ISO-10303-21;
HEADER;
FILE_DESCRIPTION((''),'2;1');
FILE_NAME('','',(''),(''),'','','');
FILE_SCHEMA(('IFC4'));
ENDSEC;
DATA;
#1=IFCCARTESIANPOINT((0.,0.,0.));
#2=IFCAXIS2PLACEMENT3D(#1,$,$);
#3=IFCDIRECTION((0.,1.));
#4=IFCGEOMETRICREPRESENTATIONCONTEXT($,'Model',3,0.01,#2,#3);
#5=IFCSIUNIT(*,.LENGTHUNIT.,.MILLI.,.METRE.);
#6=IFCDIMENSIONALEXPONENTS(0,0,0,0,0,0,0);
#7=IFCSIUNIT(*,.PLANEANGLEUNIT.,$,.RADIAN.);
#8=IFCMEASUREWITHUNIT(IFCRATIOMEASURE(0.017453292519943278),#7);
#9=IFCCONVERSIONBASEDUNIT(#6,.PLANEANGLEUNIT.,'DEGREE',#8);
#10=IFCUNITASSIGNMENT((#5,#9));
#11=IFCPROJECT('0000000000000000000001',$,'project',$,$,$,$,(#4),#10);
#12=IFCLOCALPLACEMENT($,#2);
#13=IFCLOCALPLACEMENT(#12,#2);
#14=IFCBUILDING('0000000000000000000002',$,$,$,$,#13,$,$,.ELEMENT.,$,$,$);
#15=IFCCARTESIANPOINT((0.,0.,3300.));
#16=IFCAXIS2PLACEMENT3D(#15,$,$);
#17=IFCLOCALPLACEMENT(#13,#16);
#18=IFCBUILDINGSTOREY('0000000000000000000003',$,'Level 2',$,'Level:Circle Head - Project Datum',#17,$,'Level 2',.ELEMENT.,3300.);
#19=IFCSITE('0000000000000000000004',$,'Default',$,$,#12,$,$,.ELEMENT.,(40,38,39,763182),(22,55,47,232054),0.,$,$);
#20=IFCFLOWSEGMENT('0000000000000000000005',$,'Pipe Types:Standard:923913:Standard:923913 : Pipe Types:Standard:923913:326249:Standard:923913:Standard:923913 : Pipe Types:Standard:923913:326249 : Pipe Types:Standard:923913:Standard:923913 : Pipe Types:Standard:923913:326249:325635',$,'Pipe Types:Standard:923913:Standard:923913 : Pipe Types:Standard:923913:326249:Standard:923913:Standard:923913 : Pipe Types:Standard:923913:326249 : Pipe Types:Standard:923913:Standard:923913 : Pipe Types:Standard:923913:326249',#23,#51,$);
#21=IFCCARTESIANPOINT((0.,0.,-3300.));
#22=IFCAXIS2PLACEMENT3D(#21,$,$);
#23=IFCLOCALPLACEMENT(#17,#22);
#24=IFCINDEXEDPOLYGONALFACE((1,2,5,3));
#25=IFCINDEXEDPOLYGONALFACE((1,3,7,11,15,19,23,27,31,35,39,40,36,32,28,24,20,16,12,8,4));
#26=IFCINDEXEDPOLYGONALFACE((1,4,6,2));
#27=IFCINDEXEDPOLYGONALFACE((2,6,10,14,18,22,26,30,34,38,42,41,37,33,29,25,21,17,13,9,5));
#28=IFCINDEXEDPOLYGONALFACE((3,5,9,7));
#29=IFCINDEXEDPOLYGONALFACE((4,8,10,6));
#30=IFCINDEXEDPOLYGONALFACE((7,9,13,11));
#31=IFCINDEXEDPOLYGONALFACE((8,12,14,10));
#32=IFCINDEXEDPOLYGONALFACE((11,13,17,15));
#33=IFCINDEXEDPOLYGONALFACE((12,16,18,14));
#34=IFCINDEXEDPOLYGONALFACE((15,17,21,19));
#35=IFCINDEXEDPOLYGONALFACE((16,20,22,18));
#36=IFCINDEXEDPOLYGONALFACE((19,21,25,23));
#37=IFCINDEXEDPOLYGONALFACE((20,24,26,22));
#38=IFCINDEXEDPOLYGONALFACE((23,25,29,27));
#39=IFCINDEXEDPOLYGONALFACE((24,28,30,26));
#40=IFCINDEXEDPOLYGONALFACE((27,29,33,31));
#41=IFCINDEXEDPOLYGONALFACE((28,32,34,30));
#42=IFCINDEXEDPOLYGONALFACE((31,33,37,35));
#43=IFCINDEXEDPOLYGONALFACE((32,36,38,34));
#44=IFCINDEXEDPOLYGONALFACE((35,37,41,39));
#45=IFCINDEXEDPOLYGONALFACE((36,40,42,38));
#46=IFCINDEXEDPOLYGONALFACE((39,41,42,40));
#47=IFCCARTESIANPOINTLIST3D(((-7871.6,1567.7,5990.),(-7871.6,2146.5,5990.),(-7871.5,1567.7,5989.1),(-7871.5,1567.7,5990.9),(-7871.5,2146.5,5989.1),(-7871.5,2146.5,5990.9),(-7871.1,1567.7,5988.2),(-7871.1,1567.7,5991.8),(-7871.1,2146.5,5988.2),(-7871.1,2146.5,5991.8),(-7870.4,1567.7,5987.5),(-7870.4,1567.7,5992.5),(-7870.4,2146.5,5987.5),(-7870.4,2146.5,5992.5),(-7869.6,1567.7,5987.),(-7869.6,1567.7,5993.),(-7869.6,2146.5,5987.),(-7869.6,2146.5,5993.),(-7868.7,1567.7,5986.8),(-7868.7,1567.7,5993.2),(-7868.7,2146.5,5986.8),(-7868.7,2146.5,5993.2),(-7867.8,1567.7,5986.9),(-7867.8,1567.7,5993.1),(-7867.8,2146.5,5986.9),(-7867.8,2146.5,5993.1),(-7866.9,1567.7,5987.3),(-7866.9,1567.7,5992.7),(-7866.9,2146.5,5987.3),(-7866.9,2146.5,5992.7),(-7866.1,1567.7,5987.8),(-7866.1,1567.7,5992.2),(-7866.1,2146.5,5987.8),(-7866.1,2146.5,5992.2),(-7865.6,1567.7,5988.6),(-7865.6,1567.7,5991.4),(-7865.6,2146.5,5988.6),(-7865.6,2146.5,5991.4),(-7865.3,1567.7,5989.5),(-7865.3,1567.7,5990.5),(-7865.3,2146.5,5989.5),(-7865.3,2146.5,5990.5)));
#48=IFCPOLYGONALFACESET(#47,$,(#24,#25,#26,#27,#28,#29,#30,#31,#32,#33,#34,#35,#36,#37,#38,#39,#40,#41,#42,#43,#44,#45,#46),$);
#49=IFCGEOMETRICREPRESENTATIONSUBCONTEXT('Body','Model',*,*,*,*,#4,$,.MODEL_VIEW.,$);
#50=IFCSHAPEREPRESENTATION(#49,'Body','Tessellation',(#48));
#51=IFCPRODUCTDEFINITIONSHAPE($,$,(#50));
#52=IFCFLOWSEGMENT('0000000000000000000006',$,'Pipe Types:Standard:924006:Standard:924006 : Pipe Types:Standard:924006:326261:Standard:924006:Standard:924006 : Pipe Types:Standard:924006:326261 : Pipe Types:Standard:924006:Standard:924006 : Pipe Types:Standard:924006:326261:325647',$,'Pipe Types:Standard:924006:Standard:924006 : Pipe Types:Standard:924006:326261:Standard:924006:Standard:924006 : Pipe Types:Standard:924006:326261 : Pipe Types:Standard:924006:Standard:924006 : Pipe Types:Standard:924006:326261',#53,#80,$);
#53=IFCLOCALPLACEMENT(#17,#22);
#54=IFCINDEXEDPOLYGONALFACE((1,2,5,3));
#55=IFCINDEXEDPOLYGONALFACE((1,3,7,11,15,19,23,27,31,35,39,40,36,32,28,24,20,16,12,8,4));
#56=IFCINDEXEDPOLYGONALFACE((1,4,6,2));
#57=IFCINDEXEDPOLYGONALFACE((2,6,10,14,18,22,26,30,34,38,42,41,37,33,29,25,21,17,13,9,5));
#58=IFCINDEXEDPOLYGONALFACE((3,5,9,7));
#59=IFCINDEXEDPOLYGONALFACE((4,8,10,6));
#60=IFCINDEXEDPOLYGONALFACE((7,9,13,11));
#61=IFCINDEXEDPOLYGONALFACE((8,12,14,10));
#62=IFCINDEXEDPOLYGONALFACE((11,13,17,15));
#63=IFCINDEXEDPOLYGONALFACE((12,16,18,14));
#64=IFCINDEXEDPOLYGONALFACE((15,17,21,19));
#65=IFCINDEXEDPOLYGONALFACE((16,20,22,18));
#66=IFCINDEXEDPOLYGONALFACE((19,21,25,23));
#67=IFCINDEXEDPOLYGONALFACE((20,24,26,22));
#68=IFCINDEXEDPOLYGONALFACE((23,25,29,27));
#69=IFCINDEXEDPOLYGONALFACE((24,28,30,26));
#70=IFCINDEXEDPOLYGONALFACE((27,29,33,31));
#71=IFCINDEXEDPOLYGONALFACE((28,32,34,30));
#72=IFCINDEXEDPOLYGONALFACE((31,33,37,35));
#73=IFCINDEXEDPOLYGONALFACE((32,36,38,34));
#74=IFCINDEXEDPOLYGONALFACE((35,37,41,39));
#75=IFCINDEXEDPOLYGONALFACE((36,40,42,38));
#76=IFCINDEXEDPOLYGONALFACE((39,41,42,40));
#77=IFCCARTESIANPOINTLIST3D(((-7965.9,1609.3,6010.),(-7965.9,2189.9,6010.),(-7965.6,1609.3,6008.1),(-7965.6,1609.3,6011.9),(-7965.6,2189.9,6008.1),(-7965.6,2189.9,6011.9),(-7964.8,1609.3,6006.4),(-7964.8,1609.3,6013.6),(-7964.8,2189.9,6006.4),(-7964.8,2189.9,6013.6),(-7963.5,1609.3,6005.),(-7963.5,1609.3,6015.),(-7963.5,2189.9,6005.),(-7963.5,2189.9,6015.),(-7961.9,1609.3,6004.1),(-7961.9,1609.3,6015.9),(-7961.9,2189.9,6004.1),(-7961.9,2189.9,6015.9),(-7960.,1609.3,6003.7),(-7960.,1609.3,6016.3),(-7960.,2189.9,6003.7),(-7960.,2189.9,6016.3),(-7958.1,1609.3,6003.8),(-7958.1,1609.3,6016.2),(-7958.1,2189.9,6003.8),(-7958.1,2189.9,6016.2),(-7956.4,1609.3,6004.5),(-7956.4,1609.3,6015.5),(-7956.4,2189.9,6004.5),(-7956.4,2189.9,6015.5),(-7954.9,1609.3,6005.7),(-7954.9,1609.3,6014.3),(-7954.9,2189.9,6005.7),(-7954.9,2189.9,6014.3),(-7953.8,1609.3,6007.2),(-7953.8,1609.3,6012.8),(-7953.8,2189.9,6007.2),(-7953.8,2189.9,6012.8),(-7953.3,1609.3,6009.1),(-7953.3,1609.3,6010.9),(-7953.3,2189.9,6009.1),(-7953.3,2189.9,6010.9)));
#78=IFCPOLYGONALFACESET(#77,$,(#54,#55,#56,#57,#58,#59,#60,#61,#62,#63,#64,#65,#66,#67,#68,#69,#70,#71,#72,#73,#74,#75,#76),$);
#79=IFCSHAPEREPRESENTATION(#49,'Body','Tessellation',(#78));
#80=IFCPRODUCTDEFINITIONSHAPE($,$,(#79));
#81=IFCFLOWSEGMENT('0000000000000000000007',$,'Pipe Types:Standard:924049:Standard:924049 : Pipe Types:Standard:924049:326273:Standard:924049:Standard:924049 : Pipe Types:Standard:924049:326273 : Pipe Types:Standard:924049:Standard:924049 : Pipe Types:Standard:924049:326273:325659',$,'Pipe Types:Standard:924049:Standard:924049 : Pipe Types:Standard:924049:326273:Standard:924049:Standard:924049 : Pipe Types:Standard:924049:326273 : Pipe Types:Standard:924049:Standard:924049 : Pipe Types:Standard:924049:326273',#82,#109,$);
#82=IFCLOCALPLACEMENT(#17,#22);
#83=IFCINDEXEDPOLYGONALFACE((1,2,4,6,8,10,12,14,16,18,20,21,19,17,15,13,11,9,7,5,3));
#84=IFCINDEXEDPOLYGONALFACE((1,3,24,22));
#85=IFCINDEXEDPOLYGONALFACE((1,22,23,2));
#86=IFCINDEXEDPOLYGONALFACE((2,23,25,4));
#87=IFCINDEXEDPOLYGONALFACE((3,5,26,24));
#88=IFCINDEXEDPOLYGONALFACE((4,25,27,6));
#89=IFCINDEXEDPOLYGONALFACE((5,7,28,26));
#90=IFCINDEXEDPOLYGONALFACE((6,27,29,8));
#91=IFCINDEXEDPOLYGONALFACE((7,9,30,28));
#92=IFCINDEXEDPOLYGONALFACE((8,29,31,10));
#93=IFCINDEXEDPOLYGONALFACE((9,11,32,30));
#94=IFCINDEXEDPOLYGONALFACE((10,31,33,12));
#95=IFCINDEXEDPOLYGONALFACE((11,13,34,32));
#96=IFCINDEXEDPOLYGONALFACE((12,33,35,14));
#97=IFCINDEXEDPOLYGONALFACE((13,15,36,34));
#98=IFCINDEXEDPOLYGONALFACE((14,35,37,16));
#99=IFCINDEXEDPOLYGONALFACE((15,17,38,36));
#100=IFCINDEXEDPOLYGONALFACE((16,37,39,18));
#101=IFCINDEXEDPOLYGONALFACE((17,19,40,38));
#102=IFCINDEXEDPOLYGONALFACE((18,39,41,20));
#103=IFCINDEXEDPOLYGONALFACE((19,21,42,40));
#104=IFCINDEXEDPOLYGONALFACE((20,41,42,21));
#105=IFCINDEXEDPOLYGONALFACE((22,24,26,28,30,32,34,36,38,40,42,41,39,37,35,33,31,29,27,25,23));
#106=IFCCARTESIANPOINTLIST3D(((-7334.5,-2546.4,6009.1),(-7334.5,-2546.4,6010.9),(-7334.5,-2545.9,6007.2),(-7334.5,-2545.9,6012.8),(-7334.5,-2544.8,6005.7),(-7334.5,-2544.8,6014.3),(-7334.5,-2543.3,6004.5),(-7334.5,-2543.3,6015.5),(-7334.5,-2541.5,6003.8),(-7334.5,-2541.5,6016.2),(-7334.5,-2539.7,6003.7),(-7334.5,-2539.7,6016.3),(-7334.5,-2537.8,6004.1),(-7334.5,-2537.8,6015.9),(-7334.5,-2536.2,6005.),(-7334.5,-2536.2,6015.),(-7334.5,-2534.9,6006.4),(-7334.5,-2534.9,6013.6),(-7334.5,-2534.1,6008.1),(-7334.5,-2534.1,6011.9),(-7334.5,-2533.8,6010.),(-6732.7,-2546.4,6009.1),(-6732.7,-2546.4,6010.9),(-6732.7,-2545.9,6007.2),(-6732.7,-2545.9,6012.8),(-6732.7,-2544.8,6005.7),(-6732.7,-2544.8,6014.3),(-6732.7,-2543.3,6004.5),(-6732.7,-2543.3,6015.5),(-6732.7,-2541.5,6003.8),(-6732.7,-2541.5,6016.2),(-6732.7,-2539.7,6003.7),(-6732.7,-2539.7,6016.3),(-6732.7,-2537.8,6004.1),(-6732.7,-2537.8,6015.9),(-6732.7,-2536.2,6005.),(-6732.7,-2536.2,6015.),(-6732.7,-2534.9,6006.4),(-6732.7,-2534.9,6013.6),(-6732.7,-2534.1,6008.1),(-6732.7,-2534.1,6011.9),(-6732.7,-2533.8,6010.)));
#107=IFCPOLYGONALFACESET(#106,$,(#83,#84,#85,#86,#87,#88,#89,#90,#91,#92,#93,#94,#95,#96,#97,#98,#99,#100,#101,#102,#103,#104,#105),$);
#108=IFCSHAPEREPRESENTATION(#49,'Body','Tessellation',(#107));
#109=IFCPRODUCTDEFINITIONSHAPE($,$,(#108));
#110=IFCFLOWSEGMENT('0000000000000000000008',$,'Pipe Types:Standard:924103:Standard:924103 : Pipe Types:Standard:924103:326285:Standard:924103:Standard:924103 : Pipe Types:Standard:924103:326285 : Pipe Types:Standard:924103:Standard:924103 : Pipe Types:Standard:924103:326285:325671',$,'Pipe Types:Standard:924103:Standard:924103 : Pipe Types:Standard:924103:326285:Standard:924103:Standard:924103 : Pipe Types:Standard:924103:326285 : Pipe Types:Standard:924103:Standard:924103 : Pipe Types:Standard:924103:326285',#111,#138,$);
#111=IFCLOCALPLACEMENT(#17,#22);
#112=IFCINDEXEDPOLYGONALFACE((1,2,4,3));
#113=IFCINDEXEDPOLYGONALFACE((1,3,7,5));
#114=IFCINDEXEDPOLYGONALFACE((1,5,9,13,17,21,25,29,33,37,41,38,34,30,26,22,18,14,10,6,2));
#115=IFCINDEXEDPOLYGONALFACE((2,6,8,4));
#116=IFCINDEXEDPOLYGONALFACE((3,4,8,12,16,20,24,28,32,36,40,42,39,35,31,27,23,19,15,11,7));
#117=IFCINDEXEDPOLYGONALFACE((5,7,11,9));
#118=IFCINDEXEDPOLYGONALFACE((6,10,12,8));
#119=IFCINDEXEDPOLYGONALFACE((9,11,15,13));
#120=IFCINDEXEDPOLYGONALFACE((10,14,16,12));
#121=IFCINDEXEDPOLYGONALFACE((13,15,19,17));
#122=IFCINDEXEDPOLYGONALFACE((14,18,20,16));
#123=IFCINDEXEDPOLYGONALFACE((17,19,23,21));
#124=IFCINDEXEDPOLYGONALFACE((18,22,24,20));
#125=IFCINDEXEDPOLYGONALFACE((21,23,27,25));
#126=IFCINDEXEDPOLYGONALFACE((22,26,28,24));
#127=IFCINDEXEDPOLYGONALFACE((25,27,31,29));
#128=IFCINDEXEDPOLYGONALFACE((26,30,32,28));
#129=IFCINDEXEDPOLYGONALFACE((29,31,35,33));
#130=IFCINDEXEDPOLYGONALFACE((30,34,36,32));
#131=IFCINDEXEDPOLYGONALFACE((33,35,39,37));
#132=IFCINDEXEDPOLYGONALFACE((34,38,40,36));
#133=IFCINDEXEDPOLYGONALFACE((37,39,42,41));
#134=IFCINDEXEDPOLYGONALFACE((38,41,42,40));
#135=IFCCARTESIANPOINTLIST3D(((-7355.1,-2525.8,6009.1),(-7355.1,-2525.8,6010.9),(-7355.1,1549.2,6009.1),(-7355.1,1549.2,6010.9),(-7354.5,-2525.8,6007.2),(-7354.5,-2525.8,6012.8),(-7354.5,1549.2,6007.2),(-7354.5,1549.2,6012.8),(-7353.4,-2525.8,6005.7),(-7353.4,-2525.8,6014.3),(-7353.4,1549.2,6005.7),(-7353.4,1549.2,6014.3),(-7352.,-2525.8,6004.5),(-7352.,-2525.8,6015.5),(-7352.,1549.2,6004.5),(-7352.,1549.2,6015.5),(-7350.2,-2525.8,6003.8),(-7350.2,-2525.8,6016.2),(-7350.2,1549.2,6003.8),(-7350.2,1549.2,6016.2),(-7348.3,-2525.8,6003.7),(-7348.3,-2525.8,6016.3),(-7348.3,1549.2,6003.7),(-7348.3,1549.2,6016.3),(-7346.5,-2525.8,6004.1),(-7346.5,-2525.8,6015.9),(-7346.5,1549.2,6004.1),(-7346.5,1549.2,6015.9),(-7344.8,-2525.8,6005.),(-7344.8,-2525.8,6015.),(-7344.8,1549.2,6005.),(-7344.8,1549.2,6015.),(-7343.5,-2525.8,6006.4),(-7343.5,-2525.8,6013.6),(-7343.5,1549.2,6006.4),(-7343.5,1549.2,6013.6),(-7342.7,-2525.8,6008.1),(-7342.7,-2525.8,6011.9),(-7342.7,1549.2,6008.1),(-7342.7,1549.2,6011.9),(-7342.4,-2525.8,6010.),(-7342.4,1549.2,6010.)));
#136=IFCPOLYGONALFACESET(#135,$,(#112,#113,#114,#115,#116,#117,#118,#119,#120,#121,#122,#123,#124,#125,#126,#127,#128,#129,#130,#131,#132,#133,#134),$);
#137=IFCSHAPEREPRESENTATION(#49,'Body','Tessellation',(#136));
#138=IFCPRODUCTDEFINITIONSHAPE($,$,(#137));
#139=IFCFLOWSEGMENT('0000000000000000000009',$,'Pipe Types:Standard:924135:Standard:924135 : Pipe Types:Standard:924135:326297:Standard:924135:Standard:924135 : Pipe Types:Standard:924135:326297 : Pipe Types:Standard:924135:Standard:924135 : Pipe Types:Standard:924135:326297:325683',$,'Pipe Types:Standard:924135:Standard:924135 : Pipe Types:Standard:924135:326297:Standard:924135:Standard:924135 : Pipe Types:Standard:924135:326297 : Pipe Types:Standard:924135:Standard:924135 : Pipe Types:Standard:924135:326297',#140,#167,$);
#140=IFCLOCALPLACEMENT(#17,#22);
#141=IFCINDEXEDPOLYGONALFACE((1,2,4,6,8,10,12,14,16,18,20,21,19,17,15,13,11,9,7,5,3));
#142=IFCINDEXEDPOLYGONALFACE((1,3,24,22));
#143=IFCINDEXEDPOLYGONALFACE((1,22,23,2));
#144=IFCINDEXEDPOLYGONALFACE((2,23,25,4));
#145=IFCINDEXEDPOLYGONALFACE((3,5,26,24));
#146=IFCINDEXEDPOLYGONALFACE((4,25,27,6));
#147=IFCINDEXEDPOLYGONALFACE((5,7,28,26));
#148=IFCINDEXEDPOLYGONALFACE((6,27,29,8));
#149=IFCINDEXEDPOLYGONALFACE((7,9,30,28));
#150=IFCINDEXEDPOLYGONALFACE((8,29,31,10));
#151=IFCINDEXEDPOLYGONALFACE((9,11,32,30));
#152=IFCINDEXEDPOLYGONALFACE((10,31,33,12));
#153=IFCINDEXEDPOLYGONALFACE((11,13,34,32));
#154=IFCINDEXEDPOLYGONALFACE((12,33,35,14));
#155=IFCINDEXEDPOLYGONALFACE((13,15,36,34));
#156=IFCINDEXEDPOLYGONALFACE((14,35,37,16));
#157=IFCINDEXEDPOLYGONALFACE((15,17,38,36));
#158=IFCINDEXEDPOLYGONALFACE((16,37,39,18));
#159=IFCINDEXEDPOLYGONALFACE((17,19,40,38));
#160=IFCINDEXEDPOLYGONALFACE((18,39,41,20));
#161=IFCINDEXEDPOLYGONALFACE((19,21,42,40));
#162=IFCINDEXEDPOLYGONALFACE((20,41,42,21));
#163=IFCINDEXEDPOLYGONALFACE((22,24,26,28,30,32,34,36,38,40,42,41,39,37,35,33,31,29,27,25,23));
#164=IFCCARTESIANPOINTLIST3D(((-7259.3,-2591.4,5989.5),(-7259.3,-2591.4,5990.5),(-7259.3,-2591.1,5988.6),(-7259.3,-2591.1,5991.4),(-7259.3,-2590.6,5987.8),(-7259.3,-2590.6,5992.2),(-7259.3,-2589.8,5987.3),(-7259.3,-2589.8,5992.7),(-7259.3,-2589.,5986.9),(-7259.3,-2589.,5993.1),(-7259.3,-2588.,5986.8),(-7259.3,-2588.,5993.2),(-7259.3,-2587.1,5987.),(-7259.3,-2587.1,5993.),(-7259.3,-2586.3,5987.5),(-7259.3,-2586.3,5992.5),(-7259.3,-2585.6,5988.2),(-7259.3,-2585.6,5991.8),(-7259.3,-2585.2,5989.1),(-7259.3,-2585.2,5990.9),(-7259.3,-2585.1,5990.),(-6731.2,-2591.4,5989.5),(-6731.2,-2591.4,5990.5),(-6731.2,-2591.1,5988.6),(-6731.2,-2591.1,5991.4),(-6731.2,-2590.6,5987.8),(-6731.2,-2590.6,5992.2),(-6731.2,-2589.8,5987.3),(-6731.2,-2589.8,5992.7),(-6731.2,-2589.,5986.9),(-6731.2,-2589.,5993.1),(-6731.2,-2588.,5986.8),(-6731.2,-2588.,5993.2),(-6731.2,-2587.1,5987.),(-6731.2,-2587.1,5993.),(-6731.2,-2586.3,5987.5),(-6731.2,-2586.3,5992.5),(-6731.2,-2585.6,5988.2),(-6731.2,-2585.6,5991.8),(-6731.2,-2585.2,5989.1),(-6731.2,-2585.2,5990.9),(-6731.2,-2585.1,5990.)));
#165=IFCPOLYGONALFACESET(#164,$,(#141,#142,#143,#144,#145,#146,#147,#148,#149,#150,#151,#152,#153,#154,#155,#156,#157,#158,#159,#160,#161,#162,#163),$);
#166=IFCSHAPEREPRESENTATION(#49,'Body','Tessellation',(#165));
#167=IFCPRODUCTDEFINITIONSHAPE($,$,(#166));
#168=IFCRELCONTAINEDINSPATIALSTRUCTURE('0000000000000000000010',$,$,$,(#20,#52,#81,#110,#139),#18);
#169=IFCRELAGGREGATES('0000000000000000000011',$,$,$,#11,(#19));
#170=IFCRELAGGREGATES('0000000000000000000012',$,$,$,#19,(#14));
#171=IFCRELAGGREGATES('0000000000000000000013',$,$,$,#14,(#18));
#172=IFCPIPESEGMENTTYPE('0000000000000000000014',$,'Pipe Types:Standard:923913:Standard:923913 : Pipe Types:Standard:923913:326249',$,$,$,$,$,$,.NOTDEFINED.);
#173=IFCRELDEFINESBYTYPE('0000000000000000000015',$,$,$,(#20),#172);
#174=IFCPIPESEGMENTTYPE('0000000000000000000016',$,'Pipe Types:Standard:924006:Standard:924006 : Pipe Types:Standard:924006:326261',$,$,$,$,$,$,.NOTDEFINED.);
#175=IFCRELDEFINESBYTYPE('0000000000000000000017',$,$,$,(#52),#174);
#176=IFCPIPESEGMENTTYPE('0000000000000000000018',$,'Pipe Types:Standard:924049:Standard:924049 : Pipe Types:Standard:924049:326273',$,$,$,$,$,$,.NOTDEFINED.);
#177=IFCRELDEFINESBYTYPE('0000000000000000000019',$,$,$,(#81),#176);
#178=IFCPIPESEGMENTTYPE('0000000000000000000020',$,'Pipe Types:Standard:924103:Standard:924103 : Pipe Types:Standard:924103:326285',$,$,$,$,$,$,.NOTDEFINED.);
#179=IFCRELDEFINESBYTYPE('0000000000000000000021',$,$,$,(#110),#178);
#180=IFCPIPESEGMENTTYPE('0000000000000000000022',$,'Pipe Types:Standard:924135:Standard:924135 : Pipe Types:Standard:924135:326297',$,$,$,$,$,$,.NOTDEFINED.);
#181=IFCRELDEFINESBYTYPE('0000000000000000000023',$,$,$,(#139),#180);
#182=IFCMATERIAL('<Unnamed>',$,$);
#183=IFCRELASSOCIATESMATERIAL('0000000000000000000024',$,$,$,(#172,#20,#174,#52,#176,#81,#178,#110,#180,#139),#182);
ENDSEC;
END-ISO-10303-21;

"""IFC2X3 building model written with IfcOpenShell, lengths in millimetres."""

from ifc_helpers import new_model, entity, si_unit, converted_unit, direction, frame, origin, origin_2d_with_axis, place, context, subcontext, project, spatial, circle, extrude, source, transform, mapped, material, type_object, type_shapes, element, save


model = new_model("IFC2X3")

# Units and contexts
model_context = context("Model", 3, precision=0.01, world=origin(), true_north=direction((0.0, 1.0)))
body_context = subcontext(model_context, "Body", "Model", "MODEL_VIEW")
ifc_project = project(units=[si_unit("LENGTHUNIT", "METRE", prefix="MILLI"), converted_unit("PLANEANGLEUNIT", "DEGREE", entity("IfcRatioMeasure", 0.017453292519943278), si_unit("PLANEANGLEUNIT", "RADIAN"), dimensions=[0, 0, 0, 0, 0, 0, 0])], contexts=[model_context])

# Site, building, storey
site_placement = place(None, origin())
site = spatial("IfcSite", under=ifc_project, at=site_placement, Name="Default", CompositionType="ELEMENT", RefLatitude=(40, 38, 39, 763182), RefLongitude=(22, 55, 47, 232054), RefElevation=0.0)
building_placement = place(site_placement, origin())
building = spatial("IfcBuilding", under=site, at=building_placement, CompositionType="ELEMENT")
storey_placement = place(building_placement, frame((0.0, 0.0, 3300.0)))
storey = spatial("IfcBuildingStorey", under=building, at=storey_placement, Name="Level 2", ObjectType="Level:Circle Head - Project Datum", LongName="Level 2", CompositionType="ELEMENT", Elevation=3300.0)

# Flow segments
ifc_material_1 = material(Name="<Unnamed>")
pipe_segment_type_1 = type_object("IfcPipeSegmentType", Name="Pipe Types:Standard:923913:Standard:923913 : Pipe Types:Standard:923913:326249", PredefinedType="NOTDEFINED", material=ifc_material_1)
shared_shape_1 = source(origin(), body_context, "Body", "SweptSolid", [
    extrude(circle(Radius=3.2, at=origin_2d_with_axis()), frame((-7868.5, 1567.7, 5990.0), z_axis=(0.0, 1.0, 0.0), x_axis=(-1.0, 0.0, 0.0)), (0.0, 0.0, 1.0), 578.8),
])
type_shapes(pipe_segment_type_1, [shared_shape_1])
flow_segment_1_placement = place(storey_placement, frame((0.0, 0.0, -3300.0)))
element("IfcFlowSegment", 1, at=flow_segment_1_placement, inside=storey, type_object=pipe_segment_type_1, material=ifc_material_1, Name="Pipe Types:Standard:923913:Standard:923913 : Pipe Types:Standard:923913:326249:Standard:923913:Standard:923913 : Pipe Types:Standard:923913:326249 : Pipe Types:Standard:923913:Standard:923913 : Pipe Types:Standard:923913:326249:325635", ObjectType="Pipe Types:Standard:923913:Standard:923913 : Pipe Types:Standard:923913:326249:Standard:923913:Standard:923913 : Pipe Types:Standard:923913:326249 : Pipe Types:Standard:923913:Standard:923913 : Pipe Types:Standard:923913:326249", context=body_context, shape_type="MappedRepresentation", body=[
    mapped(shared_shape_1, transform((0.0, 0.0, 0.0), scale=1.0)),
])
pipe_segment_type_2 = type_object("IfcPipeSegmentType", Name="Pipe Types:Standard:924006:Standard:924006 : Pipe Types:Standard:924006:326261", PredefinedType="NOTDEFINED", material=ifc_material_1)
shared_shape_2 = source(origin(), body_context, "Body", "SweptSolid", [
    extrude(circle(Radius=6.3, at=origin_2d_with_axis()), frame((-7959.6, 1609.3, 6010.0), z_axis=(0.0, 1.0, 0.0), x_axis=(-1.0, 0.0, 0.0)), (0.0, 0.0, 1.0), 580.6),
])
type_shapes(pipe_segment_type_2, [shared_shape_2])
flow_segment_2_placement = place(storey_placement, frame((0.0, 0.0, -3300.0)))
element("IfcFlowSegment", 2, at=flow_segment_2_placement, inside=storey, type_object=pipe_segment_type_2, material=ifc_material_1, Name="Pipe Types:Standard:924006:Standard:924006 : Pipe Types:Standard:924006:326261:Standard:924006:Standard:924006 : Pipe Types:Standard:924006:326261 : Pipe Types:Standard:924006:Standard:924006 : Pipe Types:Standard:924006:326261:325647", ObjectType="Pipe Types:Standard:924006:Standard:924006 : Pipe Types:Standard:924006:326261:Standard:924006:Standard:924006 : Pipe Types:Standard:924006:326261 : Pipe Types:Standard:924006:Standard:924006 : Pipe Types:Standard:924006:326261", context=body_context, shape_type="MappedRepresentation", body=[
    mapped(shared_shape_2, transform((0.0, 0.0, 0.0), scale=1.0)),
])
pipe_segment_type_3 = type_object("IfcPipeSegmentType", Name="Pipe Types:Standard:924049:Standard:924049 : Pipe Types:Standard:924049:326273", PredefinedType="NOTDEFINED", material=ifc_material_1)
shared_shape_3 = source(origin(), body_context, "Body", "SweptSolid", [
    extrude(circle(Radius=6.3, at=origin_2d_with_axis()), frame((-7334.5, -2540.1, 6010.0), z_axis=(1.0, 0.0, 0.0), x_axis=(0.0, 1.0, 0.0)), (0.0, 0.0, 1.0), 601.7),
])
type_shapes(pipe_segment_type_3, [shared_shape_3])
flow_segment_3_placement = place(storey_placement, frame((0.0, 0.0, -3300.0)))
element("IfcFlowSegment", 3, at=flow_segment_3_placement, inside=storey, type_object=pipe_segment_type_3, material=ifc_material_1, Name="Pipe Types:Standard:924049:Standard:924049 : Pipe Types:Standard:924049:326273:Standard:924049:Standard:924049 : Pipe Types:Standard:924049:326273 : Pipe Types:Standard:924049:Standard:924049 : Pipe Types:Standard:924049:326273:325659", ObjectType="Pipe Types:Standard:924049:Standard:924049 : Pipe Types:Standard:924049:326273:Standard:924049:Standard:924049 : Pipe Types:Standard:924049:326273 : Pipe Types:Standard:924049:Standard:924049 : Pipe Types:Standard:924049:326273", context=body_context, shape_type="MappedRepresentation", body=[
    mapped(shared_shape_3, transform((0.0, 0.0, 0.0), scale=1.0)),
])
pipe_segment_type_4 = type_object("IfcPipeSegmentType", Name="Pipe Types:Standard:924103:Standard:924103 : Pipe Types:Standard:924103:326285", PredefinedType="NOTDEFINED", material=ifc_material_1)
shared_shape_4 = source(origin(), body_context, "Body", "SweptSolid", [
    extrude(circle(Radius=6.3, at=origin_2d_with_axis()), frame((-7348.8, -2525.8, 6010.0), z_axis=(0.0, 1.0, 0.0), x_axis=(1.0, 0.0, 0.0)), (0.0, 0.0, 1.0), 4075.0),
])
type_shapes(pipe_segment_type_4, [shared_shape_4])
flow_segment_4_placement = place(storey_placement, frame((0.0, 0.0, -3300.0)))
element("IfcFlowSegment", 4, at=flow_segment_4_placement, inside=storey, type_object=pipe_segment_type_4, material=ifc_material_1, Name="Pipe Types:Standard:924103:Standard:924103 : Pipe Types:Standard:924103:326285:Standard:924103:Standard:924103 : Pipe Types:Standard:924103:326285 : Pipe Types:Standard:924103:Standard:924103 : Pipe Types:Standard:924103:326285:325671", ObjectType="Pipe Types:Standard:924103:Standard:924103 : Pipe Types:Standard:924103:326285:Standard:924103:Standard:924103 : Pipe Types:Standard:924103:326285 : Pipe Types:Standard:924103:Standard:924103 : Pipe Types:Standard:924103:326285", context=body_context, shape_type="MappedRepresentation", body=[
    mapped(shared_shape_4, transform((0.0, 0.0, 0.0), scale=1.0)),
])
pipe_segment_type_5 = type_object("IfcPipeSegmentType", Name="Pipe Types:Standard:924135:Standard:924135 : Pipe Types:Standard:924135:326297", PredefinedType="NOTDEFINED", material=ifc_material_1)
shared_shape_5 = source(origin(), body_context, "Body", "SweptSolid", [
    extrude(circle(Radius=3.2, at=origin_2d_with_axis()), frame((-7259.3, -2588.3, 5990.0), z_axis=(1.0, 0.0, 0.0), x_axis=(0.0, 1.0, 0.0)), (0.0, 0.0, 1.0), 528.1),
])
type_shapes(pipe_segment_type_5, [shared_shape_5])
flow_segment_5_placement = place(storey_placement, frame((0.0, 0.0, -3300.0)))
element("IfcFlowSegment", 5, at=flow_segment_5_placement, inside=storey, type_object=pipe_segment_type_5, material=ifc_material_1, Name="Pipe Types:Standard:924135:Standard:924135 : Pipe Types:Standard:924135:326297:Standard:924135:Standard:924135 : Pipe Types:Standard:924135:326297 : Pipe Types:Standard:924135:Standard:924135 : Pipe Types:Standard:924135:326297:325683", ObjectType="Pipe Types:Standard:924135:Standard:924135 : Pipe Types:Standard:924135:326297:Standard:924135:Standard:924135 : Pipe Types:Standard:924135:326297 : Pipe Types:Standard:924135:Standard:924135 : Pipe Types:Standard:924135:326297", context=body_context, shape_type="MappedRepresentation", body=[
    mapped(shared_shape_5, transform((0.0, 0.0, 0.0), scale=1.0)),
])

save(model, "model.ifc")
